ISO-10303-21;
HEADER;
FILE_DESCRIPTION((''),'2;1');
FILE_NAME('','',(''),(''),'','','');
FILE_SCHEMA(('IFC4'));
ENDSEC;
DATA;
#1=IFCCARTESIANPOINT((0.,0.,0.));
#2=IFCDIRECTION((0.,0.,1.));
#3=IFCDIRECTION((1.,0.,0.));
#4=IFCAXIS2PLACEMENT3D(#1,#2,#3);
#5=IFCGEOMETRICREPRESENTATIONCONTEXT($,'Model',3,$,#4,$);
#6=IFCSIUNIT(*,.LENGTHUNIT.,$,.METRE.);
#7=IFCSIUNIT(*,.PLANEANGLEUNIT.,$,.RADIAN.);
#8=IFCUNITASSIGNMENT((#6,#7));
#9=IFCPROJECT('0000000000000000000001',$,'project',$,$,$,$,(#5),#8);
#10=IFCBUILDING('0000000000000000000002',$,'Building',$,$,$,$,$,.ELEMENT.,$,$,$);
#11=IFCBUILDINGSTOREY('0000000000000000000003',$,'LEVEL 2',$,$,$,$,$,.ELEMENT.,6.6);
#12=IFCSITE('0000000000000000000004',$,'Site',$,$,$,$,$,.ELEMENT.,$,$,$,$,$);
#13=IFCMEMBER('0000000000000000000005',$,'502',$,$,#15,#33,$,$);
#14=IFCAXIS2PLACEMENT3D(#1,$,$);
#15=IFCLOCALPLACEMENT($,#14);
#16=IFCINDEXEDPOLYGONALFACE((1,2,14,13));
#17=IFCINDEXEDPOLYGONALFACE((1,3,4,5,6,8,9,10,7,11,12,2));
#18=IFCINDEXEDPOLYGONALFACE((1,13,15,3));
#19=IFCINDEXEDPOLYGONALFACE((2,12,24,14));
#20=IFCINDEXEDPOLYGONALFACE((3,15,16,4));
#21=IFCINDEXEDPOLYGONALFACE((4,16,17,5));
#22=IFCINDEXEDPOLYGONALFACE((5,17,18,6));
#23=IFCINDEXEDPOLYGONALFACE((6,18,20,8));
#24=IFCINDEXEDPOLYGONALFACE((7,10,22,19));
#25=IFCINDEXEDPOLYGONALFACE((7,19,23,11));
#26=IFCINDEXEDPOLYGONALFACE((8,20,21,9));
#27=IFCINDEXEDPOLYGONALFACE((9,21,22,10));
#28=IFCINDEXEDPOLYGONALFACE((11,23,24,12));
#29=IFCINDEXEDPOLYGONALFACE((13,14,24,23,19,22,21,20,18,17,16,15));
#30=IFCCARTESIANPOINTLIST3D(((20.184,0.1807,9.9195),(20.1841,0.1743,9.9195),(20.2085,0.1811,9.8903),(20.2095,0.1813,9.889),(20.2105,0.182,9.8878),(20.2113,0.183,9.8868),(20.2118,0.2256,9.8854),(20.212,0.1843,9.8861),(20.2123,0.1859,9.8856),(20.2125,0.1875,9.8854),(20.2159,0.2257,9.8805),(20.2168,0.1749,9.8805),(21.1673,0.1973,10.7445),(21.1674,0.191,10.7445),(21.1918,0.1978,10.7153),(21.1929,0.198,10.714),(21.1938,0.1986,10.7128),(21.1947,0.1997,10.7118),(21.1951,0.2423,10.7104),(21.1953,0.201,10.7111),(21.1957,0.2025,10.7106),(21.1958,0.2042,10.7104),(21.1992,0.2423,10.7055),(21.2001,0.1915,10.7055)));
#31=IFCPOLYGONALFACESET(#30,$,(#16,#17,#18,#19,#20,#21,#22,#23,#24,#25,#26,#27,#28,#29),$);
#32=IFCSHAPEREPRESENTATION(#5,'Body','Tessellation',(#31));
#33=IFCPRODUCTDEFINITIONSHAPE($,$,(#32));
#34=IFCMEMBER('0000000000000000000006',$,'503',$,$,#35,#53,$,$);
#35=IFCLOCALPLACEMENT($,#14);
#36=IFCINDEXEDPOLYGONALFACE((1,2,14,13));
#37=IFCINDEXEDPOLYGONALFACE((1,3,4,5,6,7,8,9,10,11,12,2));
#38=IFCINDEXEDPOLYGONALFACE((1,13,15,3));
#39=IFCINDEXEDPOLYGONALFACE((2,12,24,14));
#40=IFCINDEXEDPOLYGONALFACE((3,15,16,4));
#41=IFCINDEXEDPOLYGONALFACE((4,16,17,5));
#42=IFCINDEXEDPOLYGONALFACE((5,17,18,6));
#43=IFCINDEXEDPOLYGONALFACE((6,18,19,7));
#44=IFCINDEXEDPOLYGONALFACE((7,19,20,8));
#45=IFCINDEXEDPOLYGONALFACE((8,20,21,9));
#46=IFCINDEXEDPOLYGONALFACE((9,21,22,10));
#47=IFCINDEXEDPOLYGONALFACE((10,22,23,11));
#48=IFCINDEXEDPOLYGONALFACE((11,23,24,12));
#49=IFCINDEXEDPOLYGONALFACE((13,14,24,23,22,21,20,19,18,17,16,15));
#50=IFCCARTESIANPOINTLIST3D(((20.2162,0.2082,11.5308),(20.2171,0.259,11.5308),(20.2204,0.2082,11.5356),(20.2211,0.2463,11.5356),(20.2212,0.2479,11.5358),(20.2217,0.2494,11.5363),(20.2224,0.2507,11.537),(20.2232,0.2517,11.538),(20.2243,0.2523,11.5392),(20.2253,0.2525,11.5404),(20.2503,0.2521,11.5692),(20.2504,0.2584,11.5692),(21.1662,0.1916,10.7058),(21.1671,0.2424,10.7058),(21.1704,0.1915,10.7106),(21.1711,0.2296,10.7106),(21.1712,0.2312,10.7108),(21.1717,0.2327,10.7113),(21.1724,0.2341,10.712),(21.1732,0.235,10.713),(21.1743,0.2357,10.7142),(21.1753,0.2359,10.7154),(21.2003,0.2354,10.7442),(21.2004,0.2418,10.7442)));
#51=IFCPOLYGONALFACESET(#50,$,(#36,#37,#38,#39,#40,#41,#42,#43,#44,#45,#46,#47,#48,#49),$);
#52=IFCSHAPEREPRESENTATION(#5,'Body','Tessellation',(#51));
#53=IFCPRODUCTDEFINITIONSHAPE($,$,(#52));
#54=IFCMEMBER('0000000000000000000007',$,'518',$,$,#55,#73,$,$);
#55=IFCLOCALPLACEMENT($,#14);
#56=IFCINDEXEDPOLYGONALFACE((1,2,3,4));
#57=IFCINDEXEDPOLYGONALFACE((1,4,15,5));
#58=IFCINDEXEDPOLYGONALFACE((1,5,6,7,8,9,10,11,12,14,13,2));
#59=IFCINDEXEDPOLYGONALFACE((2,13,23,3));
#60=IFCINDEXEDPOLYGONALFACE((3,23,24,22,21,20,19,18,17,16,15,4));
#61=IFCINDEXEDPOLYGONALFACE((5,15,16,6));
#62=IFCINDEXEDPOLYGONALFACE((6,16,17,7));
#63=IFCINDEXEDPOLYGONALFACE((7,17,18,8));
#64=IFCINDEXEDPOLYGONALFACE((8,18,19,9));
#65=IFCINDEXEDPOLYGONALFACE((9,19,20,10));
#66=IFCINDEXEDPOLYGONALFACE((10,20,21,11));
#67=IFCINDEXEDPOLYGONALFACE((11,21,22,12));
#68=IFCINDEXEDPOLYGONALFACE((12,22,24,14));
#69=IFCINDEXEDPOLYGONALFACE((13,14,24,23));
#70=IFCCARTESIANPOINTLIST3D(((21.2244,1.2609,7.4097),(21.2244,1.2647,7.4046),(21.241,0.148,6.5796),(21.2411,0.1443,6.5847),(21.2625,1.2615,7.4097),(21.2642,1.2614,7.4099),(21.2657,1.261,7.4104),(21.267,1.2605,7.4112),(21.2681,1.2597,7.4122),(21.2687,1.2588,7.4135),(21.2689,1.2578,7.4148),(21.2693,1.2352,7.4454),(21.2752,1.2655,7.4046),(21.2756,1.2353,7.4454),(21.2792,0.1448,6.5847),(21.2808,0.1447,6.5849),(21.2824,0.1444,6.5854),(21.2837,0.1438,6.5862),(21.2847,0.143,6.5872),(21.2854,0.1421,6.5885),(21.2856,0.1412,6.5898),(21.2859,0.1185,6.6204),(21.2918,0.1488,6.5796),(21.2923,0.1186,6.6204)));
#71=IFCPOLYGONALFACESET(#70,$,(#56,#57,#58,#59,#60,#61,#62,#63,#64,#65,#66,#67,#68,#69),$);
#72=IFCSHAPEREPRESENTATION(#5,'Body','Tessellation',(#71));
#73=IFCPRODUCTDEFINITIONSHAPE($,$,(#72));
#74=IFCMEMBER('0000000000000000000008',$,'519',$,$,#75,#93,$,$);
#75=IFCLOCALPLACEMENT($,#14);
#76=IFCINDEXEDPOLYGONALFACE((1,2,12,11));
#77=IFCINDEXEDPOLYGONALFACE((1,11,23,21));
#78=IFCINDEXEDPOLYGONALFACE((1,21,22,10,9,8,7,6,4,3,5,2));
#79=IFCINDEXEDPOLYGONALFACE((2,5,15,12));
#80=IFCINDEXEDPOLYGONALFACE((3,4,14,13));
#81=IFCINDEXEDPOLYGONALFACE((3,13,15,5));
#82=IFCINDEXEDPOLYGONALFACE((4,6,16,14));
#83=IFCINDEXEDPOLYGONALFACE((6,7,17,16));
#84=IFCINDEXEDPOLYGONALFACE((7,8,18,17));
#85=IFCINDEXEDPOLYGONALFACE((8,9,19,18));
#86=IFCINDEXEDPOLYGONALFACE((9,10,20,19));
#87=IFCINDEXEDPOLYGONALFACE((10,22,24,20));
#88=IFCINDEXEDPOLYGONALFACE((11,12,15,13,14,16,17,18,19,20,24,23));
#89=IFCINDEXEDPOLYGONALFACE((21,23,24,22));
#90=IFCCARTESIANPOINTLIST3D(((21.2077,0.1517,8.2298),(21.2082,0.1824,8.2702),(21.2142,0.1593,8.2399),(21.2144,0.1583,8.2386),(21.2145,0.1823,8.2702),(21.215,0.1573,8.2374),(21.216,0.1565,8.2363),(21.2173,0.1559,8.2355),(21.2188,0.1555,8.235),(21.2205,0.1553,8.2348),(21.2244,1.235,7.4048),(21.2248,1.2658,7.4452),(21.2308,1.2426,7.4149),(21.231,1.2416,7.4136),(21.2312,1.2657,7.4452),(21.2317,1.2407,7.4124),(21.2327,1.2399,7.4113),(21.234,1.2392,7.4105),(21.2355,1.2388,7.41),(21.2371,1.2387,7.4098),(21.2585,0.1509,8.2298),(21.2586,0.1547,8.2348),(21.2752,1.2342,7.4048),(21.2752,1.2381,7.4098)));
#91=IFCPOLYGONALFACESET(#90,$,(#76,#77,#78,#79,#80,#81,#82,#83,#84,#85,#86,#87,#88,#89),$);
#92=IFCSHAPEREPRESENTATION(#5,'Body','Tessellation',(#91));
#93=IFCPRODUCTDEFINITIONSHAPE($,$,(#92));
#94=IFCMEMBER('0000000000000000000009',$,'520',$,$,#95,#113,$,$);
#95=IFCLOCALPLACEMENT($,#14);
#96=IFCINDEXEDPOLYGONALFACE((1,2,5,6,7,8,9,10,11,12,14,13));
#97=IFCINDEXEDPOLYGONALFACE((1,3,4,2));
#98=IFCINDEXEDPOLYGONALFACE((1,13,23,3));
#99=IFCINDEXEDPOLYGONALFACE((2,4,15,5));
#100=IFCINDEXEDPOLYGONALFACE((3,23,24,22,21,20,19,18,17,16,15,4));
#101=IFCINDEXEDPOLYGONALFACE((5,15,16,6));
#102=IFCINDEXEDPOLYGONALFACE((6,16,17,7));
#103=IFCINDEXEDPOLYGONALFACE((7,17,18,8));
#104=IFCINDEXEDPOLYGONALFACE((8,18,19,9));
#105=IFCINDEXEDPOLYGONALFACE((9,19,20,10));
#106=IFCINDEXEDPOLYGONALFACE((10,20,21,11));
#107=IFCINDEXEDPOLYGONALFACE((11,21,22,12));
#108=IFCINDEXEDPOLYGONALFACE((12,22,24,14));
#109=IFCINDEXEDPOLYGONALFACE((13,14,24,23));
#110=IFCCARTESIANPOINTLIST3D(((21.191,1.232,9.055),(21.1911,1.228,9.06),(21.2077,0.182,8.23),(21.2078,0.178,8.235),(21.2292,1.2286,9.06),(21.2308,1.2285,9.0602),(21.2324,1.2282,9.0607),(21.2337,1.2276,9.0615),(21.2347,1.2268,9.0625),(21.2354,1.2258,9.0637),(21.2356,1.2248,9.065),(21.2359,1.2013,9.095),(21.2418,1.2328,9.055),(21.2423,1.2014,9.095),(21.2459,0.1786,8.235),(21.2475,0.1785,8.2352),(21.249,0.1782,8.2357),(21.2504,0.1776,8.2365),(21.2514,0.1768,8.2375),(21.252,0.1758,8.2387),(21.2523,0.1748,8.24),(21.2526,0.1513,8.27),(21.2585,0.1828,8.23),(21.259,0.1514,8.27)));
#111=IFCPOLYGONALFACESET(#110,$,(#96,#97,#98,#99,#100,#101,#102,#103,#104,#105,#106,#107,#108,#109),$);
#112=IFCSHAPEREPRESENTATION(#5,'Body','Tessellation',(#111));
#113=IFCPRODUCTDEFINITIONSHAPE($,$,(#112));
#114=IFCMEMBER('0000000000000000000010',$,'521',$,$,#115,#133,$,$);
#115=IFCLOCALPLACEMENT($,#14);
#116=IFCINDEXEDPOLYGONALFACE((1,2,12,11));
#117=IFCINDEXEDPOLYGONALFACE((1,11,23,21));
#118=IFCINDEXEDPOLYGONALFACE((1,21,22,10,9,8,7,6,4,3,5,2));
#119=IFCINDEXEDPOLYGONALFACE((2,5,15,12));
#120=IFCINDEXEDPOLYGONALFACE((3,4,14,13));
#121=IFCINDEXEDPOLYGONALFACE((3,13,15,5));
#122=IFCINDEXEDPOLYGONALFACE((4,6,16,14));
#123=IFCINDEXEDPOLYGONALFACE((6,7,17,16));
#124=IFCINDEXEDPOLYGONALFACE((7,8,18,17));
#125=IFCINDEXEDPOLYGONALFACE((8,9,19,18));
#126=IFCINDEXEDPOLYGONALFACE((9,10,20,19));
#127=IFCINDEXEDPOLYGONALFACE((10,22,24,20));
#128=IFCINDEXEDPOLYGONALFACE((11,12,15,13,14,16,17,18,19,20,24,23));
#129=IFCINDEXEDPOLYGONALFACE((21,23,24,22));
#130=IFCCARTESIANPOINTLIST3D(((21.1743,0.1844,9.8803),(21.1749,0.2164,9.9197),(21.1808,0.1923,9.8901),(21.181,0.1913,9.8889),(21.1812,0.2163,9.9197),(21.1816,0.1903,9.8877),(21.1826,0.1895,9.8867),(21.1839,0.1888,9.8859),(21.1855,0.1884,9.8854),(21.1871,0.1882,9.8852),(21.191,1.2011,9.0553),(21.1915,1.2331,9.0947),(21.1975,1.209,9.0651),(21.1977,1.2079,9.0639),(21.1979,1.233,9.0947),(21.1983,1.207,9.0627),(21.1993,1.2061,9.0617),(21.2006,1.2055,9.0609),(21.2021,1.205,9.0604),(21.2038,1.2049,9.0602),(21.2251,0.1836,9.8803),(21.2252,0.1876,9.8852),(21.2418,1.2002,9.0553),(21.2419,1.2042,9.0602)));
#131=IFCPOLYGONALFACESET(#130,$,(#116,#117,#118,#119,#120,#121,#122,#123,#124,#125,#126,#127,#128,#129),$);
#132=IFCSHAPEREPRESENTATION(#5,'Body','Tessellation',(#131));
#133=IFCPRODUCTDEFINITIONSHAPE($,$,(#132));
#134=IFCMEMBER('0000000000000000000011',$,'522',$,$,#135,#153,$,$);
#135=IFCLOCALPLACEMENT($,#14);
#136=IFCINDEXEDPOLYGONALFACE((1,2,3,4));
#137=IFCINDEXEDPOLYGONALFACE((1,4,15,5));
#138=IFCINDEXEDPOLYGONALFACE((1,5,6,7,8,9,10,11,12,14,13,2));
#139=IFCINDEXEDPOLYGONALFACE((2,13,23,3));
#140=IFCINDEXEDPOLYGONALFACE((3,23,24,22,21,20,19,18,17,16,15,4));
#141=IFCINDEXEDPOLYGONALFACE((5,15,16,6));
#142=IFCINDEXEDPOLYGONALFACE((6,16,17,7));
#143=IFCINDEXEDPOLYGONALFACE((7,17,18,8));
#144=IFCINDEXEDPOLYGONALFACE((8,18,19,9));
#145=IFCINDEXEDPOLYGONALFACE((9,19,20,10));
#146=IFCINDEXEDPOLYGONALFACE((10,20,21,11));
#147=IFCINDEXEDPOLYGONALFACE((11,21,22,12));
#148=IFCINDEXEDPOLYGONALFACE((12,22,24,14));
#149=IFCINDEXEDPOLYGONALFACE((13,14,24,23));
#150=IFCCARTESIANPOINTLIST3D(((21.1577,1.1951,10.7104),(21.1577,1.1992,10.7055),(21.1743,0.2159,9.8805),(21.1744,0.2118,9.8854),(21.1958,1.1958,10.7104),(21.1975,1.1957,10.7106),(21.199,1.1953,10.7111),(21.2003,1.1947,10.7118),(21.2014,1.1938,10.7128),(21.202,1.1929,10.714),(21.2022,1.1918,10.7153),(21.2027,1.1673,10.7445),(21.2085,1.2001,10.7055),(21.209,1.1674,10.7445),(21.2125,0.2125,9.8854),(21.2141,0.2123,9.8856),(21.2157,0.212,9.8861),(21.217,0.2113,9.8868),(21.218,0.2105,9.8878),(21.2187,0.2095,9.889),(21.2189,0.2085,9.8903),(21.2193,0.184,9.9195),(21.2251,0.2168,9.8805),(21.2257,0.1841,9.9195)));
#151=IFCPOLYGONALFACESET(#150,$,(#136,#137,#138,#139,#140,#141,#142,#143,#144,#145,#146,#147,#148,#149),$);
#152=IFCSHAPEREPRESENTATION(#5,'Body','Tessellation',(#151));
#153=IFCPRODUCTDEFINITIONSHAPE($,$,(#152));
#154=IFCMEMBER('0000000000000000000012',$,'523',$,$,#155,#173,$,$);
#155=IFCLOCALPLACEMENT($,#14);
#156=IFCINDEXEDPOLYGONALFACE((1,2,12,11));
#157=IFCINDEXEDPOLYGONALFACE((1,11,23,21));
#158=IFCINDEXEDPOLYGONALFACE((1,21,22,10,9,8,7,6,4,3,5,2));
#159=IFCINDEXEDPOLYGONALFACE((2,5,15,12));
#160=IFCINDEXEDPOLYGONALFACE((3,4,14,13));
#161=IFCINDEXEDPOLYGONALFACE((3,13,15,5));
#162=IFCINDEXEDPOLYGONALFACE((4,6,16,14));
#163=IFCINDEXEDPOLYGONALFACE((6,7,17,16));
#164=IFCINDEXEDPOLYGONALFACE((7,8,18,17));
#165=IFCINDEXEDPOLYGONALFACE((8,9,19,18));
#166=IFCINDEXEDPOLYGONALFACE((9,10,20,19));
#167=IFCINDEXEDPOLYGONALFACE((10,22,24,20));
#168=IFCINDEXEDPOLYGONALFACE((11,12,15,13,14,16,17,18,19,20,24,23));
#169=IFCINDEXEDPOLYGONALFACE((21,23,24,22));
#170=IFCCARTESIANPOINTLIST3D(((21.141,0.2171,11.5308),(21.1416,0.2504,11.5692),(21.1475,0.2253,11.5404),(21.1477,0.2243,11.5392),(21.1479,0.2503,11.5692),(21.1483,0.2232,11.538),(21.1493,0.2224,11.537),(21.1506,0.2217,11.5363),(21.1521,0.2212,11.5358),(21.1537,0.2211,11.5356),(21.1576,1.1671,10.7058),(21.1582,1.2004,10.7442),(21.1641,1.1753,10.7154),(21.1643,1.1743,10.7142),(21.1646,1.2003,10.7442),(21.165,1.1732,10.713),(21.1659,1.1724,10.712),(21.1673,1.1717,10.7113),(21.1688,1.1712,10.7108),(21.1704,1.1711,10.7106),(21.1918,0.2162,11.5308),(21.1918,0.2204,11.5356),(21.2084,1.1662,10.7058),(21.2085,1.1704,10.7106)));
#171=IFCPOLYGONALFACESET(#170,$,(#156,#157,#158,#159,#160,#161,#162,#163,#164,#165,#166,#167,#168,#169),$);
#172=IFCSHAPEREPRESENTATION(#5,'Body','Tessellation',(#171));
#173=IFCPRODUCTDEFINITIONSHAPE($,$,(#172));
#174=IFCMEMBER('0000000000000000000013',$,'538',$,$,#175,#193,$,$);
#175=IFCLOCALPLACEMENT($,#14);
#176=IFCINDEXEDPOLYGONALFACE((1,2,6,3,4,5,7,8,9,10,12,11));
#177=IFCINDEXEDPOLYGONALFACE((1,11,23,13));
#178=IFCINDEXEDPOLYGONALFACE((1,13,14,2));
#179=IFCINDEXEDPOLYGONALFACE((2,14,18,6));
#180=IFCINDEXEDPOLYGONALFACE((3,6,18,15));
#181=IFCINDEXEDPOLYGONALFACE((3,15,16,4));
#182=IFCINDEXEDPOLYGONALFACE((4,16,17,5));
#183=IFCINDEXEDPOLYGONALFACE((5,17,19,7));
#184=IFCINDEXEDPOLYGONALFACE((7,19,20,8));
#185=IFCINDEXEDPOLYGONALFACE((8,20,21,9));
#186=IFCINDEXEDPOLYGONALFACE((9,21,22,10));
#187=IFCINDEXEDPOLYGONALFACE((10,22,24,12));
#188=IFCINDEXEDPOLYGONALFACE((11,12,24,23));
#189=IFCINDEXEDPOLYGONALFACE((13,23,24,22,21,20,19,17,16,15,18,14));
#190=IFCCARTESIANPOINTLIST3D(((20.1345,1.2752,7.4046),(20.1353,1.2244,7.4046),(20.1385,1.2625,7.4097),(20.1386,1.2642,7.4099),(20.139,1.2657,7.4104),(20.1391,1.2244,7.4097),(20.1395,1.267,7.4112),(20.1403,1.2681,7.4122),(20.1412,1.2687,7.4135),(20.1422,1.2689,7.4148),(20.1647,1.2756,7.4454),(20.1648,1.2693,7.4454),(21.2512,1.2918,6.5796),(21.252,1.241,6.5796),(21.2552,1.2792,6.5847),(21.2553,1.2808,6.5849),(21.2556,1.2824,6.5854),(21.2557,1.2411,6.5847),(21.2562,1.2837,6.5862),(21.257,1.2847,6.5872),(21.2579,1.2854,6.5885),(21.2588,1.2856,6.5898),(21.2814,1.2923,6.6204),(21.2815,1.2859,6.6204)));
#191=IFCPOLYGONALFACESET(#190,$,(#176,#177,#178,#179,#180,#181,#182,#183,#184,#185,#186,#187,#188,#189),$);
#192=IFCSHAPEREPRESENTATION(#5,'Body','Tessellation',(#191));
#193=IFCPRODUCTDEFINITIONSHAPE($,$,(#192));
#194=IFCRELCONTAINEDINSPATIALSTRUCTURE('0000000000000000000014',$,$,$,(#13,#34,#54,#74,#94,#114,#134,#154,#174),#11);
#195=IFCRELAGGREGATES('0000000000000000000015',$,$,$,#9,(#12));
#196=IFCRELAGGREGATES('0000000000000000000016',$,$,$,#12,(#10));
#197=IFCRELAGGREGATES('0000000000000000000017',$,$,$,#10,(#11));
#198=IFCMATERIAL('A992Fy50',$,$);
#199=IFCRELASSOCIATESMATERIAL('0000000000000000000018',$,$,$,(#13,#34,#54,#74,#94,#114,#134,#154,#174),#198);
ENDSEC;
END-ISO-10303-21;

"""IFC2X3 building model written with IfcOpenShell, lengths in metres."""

from ifc_helpers import new_model, si_unit, frame, origin_with_axes, origin_2d_with_axis, place, context, project, spatial, l_section, extrude, material, element, save


model = new_model("IFC2X3")

# Units and contexts
model_context = context("Model", 3, world=origin_with_axes())
ifc_project = project(units=[si_unit("LENGTHUNIT", "METRE"), si_unit("PLANEANGLEUNIT", "RADIAN")], contexts=[model_context])

# Site, building, storey
site = spatial("IfcSite", under=ifc_project, Name="Site", CompositionType="ELEMENT")
building = spatial("IfcBuilding", under=site, Name="Building", CompositionType="ELEMENT")
storey = spatial("IfcBuildingStorey", under=building, Name="LEVEL 2", CompositionType="ELEMENT", Elevation=6.6)

# Members
ifc_material = material(Name="A992Fy50")
member_1_placement = place(None, frame((20.2, 0.2, 9.9), z_axis=(0.766024, 0.012983, 0.642681), x_axis=(-0.016947, 0.999856, 0.0)))
element("IfcMember", 1, at=member_1_placement, inside=storey, material=ifc_material, Name="502", context=model_context, shape_type="SweptSolid", body=[
    extrude(l_section(Depth=0.0508, Width=0.0508, Thickness=0.0063, FilletRadius=0.0063, at=origin_2d_with_axis()), origin_with_axes(), (0.0, 0.0, 1.0), 1.2837),
])
member_2_placement = place(None, frame((21.1833, 0.2167, 10.725), z_axis=(-0.754967, 0.013245, 0.655629), x_axis=(-0.017541, -0.999846, 0.0)))
element("IfcMember", 2, at=member_2_placement, inside=storey, material=ifc_material, Name="503", context=model_context, shape_type="SweptSolid", body=[
    extrude(l_section(Depth=0.0508, Width=0.0508, Thickness=0.0063, FilletRadius=0.0063, at=origin_2d_with_axis()), origin_with_axes(), (0.0, 0.0, 1.0), 1.2583),
])
member_3_placement = place(None, frame((21.2667, 0.1333, 6.6), z_axis=(-0.012004, 0.804243, 0.594179), x_axis=(-0.999889, -0.014924, 0.0)))
element("IfcMember", 3, at=member_3_placement, inside=storey, material=ifc_material, Name="518", context=model_context, shape_type="SweptSolid", body=[
    extrude(l_section(Depth=0.0508, Width=0.0508, Thickness=0.0063, FilletRadius=0.0063, at=origin_2d_with_axis()), origin_with_axes(), (0.0, 0.0, 1.0), 1.3885),
])
member_4_placement = place(None, frame((21.25, 1.25, 7.425), z_axis=(-0.012239, -0.795513, 0.605813), x_axis=(0.999882, -0.015383, 0.0)))
element("IfcMember", 4, at=member_4_placement, inside=storey, material=ifc_material, Name="519", context=model_context, shape_type="SweptSolid", body=[
    extrude(l_section(Depth=0.0508, Width=0.0508, Thickness=0.0063, FilletRadius=0.0063, at=origin_2d_with_axis()), origin_with_axes(), (0.0, 0.0, 1.0), 1.3618),
])
member_5_placement = place(None, frame((21.2333, 0.1667, 8.25), z_axis=(-0.01248, 0.786257, 0.617773), x_axis=(-0.999889, -0.014924, 0.0)))
element("IfcMember", 5, at=member_5_placement, inside=storey, material=ifc_material, Name="520", context=model_context, shape_type="SweptSolid", body=[
    extrude(l_section(Depth=0.0508, Width=0.0508, Thickness=0.0063, FilletRadius=0.0063, at=origin_2d_with_axis()), origin_with_axes(), (0.0, 0.0, 1.0), 1.3354),
])
member_6_placement = place(None, frame((21.2167, 1.2167, 9.075), z_axis=(-0.012729, -0.77644, 0.630062), x_axis=(0.999866, -0.016391, 0.0)))
element("IfcMember", 6, at=member_6_placement, inside=storey, material=ifc_material, Name="521", context=model_context, shape_type="SweptSolid", body=[
    extrude(l_section(Depth=0.0508, Width=0.0508, Thickness=0.0063, FilletRadius=0.0063, at=origin_2d_with_axis()), origin_with_axes(), (0.0, 0.0, 1.0), 1.3094),
])
member_7_placement = place(None, frame((21.2, 0.2, 9.9), z_axis=(-0.012983, 0.766024, 0.642681), x_axis=(-0.999856, -0.016947, 0.0)))
element("IfcMember", 7, at=member_7_placement, inside=storey, material=ifc_material, Name="522", context=model_context, shape_type="SweptSolid", body=[
    extrude(l_section(Depth=0.0508, Width=0.0508, Thickness=0.0063, FilletRadius=0.0063, at=origin_2d_with_axis()), origin_with_axes(), (0.0, 0.0, 1.0), 1.2837),
])
member_8_placement = place(None, frame((21.1833, 1.1833, 10.725), z_axis=(-0.013245, -0.754967, 0.655629), x_axis=(0.999846, -0.017541, 0.0)))
element("IfcMember", 8, at=member_8_placement, inside=storey, material=ifc_material, Name="523", context=model_context, shape_type="SweptSolid", body=[
    extrude(l_section(Depth=0.0508, Width=0.0508, Thickness=0.0063, FilletRadius=0.0063, at=origin_2d_with_axis()), origin_with_axes(), (0.0, 0.0, 1.0), 1.2583),
])
member_9_placement = place(None, frame((21.2667, 1.2667, 6.6), z_axis=(-0.804243, -0.012004, 0.594179), x_axis=(0.014924, -0.999889, 0.0)))
element("IfcMember", 9, at=member_9_placement, inside=storey, material=ifc_material, Name="538", context=model_context, shape_type="SweptSolid", body=[
    extrude(l_section(Depth=0.0508, Width=0.0508, Thickness=0.0063, FilletRadius=0.0063, at=origin_2d_with_axis()), origin_with_axes(), (0.0, 0.0, 1.0), 1.3885),
])

save(model, "model.ifc")
